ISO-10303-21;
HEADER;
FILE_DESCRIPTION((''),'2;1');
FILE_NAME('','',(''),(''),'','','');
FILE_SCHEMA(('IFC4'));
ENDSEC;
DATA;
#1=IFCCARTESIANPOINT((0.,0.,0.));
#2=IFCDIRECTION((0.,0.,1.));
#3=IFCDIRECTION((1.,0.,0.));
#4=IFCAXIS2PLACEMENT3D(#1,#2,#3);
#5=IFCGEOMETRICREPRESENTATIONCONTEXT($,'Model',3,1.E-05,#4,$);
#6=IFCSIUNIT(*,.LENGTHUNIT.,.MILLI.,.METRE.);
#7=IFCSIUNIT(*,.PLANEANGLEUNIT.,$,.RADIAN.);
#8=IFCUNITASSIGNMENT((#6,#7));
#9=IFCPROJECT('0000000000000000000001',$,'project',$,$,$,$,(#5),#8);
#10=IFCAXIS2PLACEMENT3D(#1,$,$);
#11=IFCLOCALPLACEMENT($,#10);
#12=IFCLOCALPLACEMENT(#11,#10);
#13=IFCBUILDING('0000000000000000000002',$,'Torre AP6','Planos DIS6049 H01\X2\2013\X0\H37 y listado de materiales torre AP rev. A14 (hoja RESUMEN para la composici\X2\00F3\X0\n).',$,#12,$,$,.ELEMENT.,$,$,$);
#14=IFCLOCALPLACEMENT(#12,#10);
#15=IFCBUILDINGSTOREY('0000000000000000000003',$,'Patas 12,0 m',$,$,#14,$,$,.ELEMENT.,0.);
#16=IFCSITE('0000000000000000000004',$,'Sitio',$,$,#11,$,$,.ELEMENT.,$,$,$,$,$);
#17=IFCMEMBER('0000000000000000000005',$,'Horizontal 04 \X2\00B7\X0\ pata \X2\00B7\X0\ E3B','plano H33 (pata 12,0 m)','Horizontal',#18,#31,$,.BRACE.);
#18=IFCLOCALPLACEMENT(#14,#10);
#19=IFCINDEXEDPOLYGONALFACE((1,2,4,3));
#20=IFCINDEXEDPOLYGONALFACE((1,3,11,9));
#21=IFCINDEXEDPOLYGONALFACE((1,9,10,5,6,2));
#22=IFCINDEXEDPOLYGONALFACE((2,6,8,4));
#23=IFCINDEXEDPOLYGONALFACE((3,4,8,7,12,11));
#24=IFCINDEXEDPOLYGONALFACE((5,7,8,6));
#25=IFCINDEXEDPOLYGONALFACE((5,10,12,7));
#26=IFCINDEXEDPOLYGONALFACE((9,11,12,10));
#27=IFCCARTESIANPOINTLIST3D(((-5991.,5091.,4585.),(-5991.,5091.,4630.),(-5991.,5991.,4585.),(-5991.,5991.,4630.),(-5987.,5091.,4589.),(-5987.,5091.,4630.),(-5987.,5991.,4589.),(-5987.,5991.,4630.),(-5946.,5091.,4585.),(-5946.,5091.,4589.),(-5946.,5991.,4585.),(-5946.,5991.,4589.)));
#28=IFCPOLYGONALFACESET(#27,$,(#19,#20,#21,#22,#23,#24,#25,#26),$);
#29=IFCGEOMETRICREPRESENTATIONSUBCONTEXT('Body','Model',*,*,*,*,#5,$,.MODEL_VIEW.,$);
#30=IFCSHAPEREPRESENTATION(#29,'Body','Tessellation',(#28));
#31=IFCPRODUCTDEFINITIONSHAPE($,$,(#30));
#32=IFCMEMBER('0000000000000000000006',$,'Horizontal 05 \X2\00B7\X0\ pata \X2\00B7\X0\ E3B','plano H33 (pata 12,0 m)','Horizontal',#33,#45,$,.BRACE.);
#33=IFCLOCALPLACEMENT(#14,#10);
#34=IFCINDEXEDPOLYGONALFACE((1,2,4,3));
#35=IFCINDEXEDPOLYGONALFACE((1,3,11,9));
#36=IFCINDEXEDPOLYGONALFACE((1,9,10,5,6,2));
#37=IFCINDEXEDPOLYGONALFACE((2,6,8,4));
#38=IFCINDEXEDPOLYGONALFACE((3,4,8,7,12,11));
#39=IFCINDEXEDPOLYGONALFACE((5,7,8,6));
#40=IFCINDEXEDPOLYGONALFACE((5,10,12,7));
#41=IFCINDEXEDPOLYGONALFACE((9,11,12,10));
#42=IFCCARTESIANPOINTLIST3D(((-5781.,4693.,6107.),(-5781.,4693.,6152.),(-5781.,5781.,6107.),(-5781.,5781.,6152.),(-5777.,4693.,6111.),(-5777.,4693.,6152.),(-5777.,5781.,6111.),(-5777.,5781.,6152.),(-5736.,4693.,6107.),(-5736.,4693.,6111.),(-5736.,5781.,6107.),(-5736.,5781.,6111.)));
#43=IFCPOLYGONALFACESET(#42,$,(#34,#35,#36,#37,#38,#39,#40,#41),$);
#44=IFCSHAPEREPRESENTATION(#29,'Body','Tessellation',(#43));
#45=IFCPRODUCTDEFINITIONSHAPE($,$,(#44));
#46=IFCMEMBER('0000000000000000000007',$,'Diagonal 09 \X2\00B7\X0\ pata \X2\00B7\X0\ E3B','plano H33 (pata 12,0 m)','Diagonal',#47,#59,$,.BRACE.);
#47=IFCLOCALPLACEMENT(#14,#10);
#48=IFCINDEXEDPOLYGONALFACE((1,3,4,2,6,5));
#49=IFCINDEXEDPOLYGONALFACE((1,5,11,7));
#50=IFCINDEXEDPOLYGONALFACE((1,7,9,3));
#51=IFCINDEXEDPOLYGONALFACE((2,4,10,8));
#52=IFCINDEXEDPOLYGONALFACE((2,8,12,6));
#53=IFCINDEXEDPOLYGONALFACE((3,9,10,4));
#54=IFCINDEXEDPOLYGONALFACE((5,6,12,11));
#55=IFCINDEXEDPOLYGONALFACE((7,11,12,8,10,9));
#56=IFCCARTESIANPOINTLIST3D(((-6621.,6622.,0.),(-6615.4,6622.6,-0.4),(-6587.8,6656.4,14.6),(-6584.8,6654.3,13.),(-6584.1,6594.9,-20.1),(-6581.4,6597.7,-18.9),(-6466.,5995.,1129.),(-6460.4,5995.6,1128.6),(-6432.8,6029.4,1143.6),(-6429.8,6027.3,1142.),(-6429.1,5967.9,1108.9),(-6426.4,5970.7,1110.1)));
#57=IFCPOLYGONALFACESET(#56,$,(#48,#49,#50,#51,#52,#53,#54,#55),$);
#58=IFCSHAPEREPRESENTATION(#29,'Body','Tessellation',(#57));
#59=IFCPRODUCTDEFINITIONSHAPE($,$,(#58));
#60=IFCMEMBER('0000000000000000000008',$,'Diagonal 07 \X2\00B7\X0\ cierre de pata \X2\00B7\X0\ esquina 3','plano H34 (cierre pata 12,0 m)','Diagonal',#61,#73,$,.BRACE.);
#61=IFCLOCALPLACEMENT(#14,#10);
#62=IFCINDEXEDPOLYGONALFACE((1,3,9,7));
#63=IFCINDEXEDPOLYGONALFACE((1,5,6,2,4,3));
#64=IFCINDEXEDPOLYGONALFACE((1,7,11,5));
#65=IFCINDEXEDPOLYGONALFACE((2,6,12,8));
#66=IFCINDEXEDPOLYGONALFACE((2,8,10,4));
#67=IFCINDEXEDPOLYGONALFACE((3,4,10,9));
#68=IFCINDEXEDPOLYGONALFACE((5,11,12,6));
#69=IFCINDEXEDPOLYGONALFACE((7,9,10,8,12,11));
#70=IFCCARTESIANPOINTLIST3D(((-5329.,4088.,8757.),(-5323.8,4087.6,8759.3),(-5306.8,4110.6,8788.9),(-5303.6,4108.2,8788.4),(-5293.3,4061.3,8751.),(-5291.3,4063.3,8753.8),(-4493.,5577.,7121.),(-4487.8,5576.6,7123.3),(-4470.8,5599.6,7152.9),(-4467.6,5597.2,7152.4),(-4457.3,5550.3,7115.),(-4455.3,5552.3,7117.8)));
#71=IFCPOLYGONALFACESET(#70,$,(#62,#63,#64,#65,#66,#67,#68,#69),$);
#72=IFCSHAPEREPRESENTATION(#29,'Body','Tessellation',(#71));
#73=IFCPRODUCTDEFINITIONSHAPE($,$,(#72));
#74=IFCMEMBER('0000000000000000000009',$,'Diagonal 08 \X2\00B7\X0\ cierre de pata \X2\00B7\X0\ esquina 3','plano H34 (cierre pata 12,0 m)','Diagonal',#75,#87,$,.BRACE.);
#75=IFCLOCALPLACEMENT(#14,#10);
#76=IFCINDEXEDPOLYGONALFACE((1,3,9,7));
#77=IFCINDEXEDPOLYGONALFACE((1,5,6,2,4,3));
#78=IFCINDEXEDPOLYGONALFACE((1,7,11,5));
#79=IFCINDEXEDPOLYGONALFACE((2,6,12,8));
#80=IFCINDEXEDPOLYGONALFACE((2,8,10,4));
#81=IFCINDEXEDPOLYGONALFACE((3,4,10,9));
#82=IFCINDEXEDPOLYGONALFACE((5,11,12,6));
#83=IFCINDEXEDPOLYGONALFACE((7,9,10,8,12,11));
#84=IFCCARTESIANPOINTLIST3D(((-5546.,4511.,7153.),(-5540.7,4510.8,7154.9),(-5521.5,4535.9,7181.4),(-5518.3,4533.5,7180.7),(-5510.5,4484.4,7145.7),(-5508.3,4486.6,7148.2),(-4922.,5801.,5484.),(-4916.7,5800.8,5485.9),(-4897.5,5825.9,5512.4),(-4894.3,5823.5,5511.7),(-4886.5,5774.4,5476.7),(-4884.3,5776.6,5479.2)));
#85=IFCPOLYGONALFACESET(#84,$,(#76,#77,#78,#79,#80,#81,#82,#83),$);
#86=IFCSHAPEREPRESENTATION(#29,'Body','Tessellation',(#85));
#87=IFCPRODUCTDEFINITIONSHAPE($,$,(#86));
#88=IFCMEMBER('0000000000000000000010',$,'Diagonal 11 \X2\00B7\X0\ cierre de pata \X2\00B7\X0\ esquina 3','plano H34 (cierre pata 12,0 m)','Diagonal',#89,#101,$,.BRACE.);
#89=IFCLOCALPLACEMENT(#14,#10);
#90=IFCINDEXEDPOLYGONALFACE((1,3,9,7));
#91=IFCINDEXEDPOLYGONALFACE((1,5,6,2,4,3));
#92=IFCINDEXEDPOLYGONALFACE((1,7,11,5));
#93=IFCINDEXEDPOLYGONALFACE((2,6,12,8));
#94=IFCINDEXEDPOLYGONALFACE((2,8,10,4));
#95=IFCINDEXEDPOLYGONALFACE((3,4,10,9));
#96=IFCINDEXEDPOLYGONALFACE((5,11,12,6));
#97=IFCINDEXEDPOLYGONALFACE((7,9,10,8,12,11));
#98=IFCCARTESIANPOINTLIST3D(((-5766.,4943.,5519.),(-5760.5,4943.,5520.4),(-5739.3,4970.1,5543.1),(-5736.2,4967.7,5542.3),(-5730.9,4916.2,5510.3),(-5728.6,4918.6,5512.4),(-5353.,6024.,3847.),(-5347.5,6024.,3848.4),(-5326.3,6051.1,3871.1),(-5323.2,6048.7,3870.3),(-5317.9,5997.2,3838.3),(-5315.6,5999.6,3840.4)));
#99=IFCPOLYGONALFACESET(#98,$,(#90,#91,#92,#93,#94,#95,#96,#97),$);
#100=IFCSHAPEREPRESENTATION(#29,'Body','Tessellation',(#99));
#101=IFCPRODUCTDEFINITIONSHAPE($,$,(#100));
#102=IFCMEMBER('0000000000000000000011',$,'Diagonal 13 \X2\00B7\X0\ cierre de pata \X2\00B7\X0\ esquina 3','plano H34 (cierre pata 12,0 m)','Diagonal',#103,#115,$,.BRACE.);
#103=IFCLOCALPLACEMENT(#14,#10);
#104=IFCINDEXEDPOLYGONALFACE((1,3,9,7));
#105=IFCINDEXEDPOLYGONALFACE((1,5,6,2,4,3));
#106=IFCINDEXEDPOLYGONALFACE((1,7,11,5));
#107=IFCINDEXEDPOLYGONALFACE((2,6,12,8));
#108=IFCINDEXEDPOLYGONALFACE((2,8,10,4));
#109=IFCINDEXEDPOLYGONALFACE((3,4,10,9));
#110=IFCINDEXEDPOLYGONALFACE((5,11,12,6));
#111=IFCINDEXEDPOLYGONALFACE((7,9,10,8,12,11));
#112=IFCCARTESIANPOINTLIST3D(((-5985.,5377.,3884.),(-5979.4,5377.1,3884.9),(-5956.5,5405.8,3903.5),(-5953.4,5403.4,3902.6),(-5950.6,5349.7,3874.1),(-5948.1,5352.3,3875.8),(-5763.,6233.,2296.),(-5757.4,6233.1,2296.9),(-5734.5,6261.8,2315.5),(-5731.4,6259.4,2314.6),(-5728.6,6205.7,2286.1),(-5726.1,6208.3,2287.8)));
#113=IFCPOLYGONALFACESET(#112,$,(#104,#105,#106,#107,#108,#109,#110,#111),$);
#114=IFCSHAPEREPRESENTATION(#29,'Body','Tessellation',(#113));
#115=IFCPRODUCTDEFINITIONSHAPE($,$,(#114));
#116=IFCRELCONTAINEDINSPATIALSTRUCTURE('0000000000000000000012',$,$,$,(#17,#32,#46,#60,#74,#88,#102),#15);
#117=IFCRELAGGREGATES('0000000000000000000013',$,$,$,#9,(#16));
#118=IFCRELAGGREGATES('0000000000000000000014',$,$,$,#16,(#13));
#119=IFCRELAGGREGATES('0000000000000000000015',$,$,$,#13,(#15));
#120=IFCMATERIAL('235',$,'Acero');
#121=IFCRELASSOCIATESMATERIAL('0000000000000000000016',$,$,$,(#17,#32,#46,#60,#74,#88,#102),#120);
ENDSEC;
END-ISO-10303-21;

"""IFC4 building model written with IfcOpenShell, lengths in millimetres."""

from ifc_helpers import new_model, si_unit, frame, frame_2d, origin, origin_with_axes, place, context, subcontext, project, spatial, l_section, extrude, material, element, save


model = new_model("IFC4")

# Units and contexts
model_context = context("Model", 3, precision=1e-05, world=origin_with_axes())
body_context = subcontext(model_context, "Body", "Model", "MODEL_VIEW")
ifc_project = project(units=[si_unit("LENGTHUNIT", "METRE", prefix="MILLI"), si_unit("PLANEANGLEUNIT", "RADIAN")], contexts=[model_context])

# Site, building, storey
site_placement = place(None, origin())
site = spatial("IfcSite", under=ifc_project, at=site_placement, Name="Sitio", CompositionType="ELEMENT")
building_placement = place(site_placement, origin())
building = spatial("IfcBuilding", under=site, at=building_placement, Name="Torre AP6", Description="Planos DIS6049 H01–H37 y listado de materiales torre AP rev. A14 (hoja RESUMEN para la composición).", CompositionType="ELEMENT")
storey_placement = place(building_placement, origin())
storey = spatial("IfcBuildingStorey", under=building, at=storey_placement, Name="Patas 12,0 m", CompositionType="ELEMENT", Elevation=0.0)

# Members
ifc_material_1 = material(Name="235", Category="Acero")
member_1_placement = place(storey_placement, frame((-5991.0, 5991.0, 4585.0), z_axis=(0.0, -1.0, 0.0), x_axis=(1.0, 0.0, 0.0)))
element("IfcMember", 1, at=member_1_placement, inside=storey, material=ifc_material_1, Name="Horizontal 04 · pata · E3B", Description="plano H33 (pata 12,0 m)", ObjectType="Horizontal", PredefinedType="BRACE", context=body_context, shape_type="SweptSolid", body=[
    extrude(l_section(Depth=45.0, Width=45.0, Thickness=4.0, at=frame_2d((22.5, 22.5))), None, (0.0, 0.0, 1.0), 900.0),
])
member_2_placement = place(storey_placement, frame((-5781.0, 5781.0, 6107.0), z_axis=(0.0, -1.0, 0.0), x_axis=(1.0, 0.0, 0.0)))
element("IfcMember", 2, at=member_2_placement, inside=storey, material=ifc_material_1, Name="Horizontal 05 · pata · E3B", Description="plano H33 (pata 12,0 m)", ObjectType="Horizontal", PredefinedType="BRACE", context=body_context, shape_type="SweptSolid", body=[
    extrude(l_section(Depth=45.0, Width=45.0, Thickness=4.0, at=frame_2d((22.5, 22.5))), None, (0.0, 0.0, 1.0), 1088.0),
])
member_3_placement = place(storey_placement, frame((-6621.0, 6622.0, 0.0), z_axis=(0.119168, -0.482052, 0.868001), x_axis=(0.738214, -0.5416, -0.402132)))
element("IfcMember", 3, at=member_3_placement, inside=storey, material=ifc_material_1, Name="Diagonal 09 · pata · E3B", Description="plano H33 (pata 12,0 m)", ObjectType="Diagonal", PredefinedType="BRACE", context=body_context, shape_type="SweptSolid", body=[
    extrude(l_section(Depth=50.0, Width=50.0, Thickness=4.0, at=frame_2d((25.0, 25.0))), None, (0.0, 0.0, 1.0), 1300.7),
])
member_4_placement = place(storey_placement, frame((-4493.0, 5577.0, 7121.0), z_axis=(-0.353511, -0.629638, 0.691799), x_axis=(0.794235, -0.592736, -0.133621)))
element("IfcMember", 4, at=member_4_placement, inside=storey, material=ifc_material_1, Name="Diagonal 07 · cierre de pata · esquina 3", Description="plano H34 (cierre pata 12,0 m)", ObjectType="Diagonal", PredefinedType="BRACE", context=body_context, shape_type="SweptSolid", body=[
    extrude(l_section(Depth=45.0, Width=45.0, Thickness=4.0, at=frame_2d((22.5, 22.5))), None, (0.0, 0.0, 1.0), 2364.8),
])
member_5_placement = place(storey_placement, frame((-4922.0, 5801.0, 5484.0), z_axis=(-0.283665, -0.586422, 0.758712), x_axis=(0.78932, -0.592082, -0.162523)))
element("IfcMember", 5, at=member_5_placement, inside=storey, material=ifc_material_1, Name="Diagonal 08 · cierre de pata · esquina 3", Description="plano H34 (cierre pata 12,0 m)", ObjectType="Diagonal", PredefinedType="BRACE", context=body_context, shape_type="SweptSolid", body=[
    extrude(l_section(Depth=45.0, Width=45.0, Thickness=4.0, at=frame_2d((22.5, 22.5))), None, (0.0, 0.0, 1.0), 2199.8),
])
member_6_placement = place(storey_placement, frame((-5353.0, 6024.0, 3847.0), z_axis=(-0.203108, -0.531622, 0.822268), x_axis=(0.77906, -0.596444, -0.193184)))
element("IfcMember", 6, at=member_6_placement, inside=storey, material=ifc_material_1, Name="Diagonal 11 · cierre de pata · esquina 3", Description="plano H34 (cierre pata 12,0 m)", ObjectType="Diagonal", PredefinedType="BRACE", context=body_context, shape_type="SweptSolid", body=[
    extrude(l_section(Depth=45.0, Width=45.0, Thickness=4.0, at=frame_2d((22.5, 22.5))), None, (0.0, 0.0, 1.0), 2033.4),
])
member_7_placement = place(storey_placement, frame((-5763.0, 6233.0, 2296.0), z_axis=(-0.122137, -0.470944, 0.873667), x_axis=(0.764223, -0.60628, -0.219974)))
element("IfcMember", 7, at=member_7_placement, inside=storey, material=ifc_material_1, Name="Diagonal 13 · cierre de pata · esquina 3", Description="plano H34 (cierre pata 12,0 m)", ObjectType="Diagonal", PredefinedType="BRACE", context=body_context, shape_type="SweptSolid", body=[
    extrude(l_section(Depth=45.0, Width=45.0, Thickness=4.0, at=frame_2d((22.5, 22.5))), None, (0.0, 0.0, 1.0), 1817.6),
])

save(model, "model.ifc")
